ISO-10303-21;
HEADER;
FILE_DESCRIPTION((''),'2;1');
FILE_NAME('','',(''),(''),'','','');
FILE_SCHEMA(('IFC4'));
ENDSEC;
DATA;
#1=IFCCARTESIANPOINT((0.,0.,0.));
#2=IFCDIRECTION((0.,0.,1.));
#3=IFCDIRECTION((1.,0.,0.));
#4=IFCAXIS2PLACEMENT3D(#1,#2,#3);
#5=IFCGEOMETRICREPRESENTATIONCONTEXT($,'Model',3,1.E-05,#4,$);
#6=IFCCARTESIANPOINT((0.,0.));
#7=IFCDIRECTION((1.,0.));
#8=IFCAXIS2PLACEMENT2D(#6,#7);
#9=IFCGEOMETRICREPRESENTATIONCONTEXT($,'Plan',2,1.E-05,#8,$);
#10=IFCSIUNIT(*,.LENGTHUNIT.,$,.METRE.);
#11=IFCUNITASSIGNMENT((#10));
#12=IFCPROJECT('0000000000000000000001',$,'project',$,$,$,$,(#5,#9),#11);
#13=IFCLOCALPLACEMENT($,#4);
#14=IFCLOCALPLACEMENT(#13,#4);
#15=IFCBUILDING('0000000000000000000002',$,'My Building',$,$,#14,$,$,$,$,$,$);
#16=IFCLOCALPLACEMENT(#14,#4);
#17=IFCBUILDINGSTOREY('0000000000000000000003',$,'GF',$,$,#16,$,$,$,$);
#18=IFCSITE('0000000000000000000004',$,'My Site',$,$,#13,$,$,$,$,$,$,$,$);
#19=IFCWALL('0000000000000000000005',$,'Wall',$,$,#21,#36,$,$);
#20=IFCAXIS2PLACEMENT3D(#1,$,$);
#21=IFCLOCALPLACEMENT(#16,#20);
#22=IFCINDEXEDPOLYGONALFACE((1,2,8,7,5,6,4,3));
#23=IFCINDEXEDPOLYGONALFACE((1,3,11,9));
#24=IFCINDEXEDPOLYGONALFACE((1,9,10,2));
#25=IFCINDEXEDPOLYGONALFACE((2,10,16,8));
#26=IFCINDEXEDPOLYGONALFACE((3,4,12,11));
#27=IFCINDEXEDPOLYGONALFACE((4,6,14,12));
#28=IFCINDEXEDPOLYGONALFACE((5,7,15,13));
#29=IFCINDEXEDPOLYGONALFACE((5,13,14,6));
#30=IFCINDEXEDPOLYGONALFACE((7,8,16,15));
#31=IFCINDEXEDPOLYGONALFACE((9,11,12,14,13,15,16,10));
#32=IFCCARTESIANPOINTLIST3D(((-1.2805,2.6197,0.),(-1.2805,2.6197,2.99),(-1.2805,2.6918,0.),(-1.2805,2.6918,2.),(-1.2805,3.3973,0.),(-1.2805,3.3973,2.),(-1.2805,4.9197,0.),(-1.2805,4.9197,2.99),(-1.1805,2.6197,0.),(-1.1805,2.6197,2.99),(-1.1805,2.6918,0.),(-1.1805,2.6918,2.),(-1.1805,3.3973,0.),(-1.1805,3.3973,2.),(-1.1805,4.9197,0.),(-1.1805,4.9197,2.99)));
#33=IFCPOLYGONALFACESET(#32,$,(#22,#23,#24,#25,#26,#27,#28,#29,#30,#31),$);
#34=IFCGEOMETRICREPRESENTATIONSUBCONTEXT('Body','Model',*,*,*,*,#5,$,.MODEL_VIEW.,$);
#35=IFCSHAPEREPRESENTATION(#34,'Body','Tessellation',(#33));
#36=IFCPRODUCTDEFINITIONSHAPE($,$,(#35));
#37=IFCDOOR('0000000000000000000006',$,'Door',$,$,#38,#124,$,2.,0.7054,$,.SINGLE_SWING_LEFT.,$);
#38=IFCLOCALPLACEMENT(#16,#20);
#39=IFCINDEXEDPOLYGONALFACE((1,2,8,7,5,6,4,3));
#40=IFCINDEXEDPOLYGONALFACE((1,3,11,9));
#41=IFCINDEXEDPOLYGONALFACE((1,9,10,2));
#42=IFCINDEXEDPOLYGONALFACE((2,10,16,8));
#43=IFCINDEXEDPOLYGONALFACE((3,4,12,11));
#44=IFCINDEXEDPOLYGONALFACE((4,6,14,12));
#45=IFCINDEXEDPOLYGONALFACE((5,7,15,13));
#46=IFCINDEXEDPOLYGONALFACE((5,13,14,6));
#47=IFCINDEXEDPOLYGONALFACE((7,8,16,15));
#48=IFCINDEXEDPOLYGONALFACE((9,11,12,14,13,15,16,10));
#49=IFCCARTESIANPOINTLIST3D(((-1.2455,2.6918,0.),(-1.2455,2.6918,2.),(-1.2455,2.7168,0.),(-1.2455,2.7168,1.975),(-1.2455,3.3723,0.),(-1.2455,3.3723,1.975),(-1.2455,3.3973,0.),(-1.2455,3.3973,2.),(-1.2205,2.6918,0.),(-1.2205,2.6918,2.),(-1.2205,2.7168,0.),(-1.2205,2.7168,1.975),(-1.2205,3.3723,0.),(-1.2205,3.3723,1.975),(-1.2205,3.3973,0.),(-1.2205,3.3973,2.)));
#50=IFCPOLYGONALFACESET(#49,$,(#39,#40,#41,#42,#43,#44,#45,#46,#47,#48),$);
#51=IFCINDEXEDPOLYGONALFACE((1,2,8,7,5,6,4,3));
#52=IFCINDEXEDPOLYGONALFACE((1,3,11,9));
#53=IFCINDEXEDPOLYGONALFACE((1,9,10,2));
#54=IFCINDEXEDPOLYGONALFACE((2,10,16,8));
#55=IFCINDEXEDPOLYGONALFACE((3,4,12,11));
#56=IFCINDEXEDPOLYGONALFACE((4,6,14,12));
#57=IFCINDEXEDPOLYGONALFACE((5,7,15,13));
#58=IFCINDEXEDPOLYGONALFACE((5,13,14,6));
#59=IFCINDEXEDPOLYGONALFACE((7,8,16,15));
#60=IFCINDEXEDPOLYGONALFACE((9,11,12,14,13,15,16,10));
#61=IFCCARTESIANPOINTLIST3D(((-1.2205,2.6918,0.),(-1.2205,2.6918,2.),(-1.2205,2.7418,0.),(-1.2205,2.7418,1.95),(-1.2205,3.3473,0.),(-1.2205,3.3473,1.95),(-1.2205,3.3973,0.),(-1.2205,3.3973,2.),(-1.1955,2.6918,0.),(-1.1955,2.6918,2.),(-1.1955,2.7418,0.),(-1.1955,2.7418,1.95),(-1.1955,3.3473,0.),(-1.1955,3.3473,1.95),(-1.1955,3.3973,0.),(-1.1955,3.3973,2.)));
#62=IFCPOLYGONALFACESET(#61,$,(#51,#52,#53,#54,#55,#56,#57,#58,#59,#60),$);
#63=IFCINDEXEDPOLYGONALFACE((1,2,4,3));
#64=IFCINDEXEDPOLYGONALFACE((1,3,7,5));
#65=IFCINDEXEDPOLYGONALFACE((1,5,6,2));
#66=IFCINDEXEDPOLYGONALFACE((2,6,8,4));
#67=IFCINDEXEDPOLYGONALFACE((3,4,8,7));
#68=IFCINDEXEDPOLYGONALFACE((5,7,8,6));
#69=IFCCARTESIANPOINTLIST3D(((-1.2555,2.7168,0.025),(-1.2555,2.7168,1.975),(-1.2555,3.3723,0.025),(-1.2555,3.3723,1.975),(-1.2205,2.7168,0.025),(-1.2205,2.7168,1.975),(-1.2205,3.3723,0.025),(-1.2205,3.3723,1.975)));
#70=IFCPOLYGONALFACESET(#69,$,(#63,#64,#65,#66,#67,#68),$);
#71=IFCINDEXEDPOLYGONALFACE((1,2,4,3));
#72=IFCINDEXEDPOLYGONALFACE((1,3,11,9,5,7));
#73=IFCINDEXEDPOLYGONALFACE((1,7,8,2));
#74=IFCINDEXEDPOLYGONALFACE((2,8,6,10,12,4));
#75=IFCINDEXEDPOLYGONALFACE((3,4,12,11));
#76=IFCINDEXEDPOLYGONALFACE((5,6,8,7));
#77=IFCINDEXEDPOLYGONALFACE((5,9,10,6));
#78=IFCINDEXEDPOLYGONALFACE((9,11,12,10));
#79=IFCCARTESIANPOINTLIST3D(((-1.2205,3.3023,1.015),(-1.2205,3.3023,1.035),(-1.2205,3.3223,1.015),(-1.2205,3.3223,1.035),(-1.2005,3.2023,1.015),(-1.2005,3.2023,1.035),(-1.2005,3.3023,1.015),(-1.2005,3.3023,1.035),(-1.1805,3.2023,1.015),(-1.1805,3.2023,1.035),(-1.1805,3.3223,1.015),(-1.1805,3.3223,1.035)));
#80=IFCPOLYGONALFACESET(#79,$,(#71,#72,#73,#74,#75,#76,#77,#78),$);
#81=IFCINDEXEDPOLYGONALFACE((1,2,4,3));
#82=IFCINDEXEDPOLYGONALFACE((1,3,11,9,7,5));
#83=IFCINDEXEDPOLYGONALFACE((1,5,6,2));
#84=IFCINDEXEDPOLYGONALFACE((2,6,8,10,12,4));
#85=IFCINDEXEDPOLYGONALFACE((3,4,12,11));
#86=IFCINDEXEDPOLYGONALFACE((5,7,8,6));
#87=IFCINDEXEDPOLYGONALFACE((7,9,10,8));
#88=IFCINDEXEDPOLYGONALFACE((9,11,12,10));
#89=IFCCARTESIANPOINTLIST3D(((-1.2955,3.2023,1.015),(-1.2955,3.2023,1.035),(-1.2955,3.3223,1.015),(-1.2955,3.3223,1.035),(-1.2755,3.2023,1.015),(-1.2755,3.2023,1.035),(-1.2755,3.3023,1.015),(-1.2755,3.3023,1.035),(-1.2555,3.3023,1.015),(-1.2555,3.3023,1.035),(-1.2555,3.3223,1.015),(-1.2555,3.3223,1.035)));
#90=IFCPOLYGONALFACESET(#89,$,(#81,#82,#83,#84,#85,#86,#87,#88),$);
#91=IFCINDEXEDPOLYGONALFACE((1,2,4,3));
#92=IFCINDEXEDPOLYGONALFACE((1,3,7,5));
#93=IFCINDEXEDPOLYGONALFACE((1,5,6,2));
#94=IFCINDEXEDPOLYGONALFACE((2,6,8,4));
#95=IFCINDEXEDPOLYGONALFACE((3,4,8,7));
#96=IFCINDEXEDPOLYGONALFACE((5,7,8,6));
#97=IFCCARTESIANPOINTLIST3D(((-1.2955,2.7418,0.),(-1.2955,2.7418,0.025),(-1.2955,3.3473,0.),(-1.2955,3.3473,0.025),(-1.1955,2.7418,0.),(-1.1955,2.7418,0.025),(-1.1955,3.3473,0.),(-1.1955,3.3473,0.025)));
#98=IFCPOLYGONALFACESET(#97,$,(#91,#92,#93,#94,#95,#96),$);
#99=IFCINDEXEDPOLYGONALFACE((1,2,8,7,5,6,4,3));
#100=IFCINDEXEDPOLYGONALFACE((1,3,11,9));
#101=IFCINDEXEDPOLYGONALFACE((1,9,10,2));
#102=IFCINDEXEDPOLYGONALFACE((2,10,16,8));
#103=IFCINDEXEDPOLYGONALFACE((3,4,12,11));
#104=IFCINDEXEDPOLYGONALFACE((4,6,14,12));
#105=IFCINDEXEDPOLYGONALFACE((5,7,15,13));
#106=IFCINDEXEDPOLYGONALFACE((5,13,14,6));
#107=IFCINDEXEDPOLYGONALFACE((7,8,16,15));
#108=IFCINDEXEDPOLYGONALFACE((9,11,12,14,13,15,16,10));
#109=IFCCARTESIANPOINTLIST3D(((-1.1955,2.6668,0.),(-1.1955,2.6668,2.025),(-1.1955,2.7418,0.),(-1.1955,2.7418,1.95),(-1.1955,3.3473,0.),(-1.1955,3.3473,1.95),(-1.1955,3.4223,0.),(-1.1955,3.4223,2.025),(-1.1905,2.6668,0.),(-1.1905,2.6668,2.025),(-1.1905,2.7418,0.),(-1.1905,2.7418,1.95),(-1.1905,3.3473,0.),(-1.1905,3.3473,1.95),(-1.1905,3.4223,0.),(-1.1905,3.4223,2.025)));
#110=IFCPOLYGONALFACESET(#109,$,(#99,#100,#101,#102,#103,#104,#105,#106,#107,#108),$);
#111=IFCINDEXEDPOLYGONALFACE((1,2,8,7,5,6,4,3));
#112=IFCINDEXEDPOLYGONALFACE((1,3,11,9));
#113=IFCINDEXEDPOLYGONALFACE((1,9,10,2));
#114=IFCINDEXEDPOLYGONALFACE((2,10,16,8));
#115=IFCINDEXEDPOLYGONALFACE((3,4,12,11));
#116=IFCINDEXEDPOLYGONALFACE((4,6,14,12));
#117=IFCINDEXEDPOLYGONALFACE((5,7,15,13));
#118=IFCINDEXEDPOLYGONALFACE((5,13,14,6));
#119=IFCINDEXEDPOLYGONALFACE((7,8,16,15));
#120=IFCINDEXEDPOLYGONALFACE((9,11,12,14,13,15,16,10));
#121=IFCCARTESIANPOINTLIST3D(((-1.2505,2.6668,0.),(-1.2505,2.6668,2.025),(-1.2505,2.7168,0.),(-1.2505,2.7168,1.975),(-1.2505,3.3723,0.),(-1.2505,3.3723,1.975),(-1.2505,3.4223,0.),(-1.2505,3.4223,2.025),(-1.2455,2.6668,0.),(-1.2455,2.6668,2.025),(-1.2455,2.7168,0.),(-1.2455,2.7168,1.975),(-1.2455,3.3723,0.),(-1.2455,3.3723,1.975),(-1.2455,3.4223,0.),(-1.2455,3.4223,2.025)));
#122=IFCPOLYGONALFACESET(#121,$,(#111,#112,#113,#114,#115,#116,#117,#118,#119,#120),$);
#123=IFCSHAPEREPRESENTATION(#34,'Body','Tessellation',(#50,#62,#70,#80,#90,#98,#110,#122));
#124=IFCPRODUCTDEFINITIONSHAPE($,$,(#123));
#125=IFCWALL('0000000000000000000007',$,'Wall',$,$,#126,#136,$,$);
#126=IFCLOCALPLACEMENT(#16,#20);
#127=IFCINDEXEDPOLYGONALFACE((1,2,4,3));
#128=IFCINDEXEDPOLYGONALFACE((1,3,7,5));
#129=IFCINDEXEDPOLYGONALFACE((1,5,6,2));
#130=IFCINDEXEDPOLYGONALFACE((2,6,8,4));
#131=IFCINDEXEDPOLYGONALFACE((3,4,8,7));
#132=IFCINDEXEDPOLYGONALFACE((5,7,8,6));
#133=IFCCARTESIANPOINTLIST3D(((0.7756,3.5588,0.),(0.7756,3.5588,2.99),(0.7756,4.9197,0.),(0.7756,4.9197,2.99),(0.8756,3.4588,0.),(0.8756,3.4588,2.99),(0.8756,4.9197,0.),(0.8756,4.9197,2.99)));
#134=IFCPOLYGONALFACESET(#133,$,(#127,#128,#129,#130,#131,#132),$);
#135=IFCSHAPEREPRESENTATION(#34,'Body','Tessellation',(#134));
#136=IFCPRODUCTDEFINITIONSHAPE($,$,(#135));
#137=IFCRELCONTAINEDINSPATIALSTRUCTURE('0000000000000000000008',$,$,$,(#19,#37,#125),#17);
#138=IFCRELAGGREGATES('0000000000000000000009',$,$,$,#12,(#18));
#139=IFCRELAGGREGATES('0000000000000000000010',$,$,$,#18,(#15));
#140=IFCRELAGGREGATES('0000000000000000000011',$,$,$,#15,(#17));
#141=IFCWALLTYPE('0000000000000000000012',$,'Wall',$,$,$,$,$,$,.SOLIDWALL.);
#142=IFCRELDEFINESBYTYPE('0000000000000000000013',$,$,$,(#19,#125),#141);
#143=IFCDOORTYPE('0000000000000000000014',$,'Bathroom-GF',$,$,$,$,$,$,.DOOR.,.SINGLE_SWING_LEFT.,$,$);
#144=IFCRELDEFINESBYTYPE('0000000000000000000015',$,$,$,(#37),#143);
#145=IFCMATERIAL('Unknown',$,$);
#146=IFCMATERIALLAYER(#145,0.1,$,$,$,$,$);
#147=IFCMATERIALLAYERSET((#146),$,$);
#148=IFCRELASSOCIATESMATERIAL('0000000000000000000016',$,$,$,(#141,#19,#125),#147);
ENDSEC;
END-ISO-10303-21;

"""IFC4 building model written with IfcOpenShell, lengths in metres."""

from ifc_helpers import new_model, entity, si_unit, frame, origin_with_axes, origin_2d_with_axis, place, context, subcontext, project, spatial, line, indexed_curve, outline, extrude, shape, source, transform, mapped, material, layer, layer_set, layer_usage, type_object, type_shapes, element, fill, save


model = new_model("IFC4")

# Units and contexts
model_context = context("Model", 3, precision=1e-05, world=origin_with_axes())
plan_context = context("Plan", 2, precision=1e-05, world=origin_2d_with_axis())
body_context_1 = subcontext(model_context, "Body", "Model", "MODEL_VIEW")
body_context_2 = subcontext(plan_context, "Body", "Plan", "PLAN_VIEW")
ifc_project = project(units=[si_unit("LENGTHUNIT", "METRE")], contexts=[model_context, plan_context])

# Site, building, storey
site_placement = place(None, origin_with_axes())
site = spatial("IfcSite", under=ifc_project, at=site_placement, Name="My Site")
building_placement = place(site_placement, origin_with_axes())
building = spatial("IfcBuilding", under=site, at=building_placement, Name="My Building")
storey_placement = place(building_placement, origin_with_axes())
storey = spatial("IfcBuildingStorey", under=building, at=storey_placement, Name="GF")

# Shared definitions
ifc_material = material(Name="Unknown")

# Shared definitions
ifc_layer_1 = layer(ifc_material, 0.1)
ifc_layer_set_1 = layer_set([ifc_layer_1])
wall_type = type_object("IfcWallType", Name="Wall", PredefinedType="SOLIDWALL", material=ifc_layer_set_1)

# Wall, opening, door
ifc_layer_usage_1 = layer_usage(ifc_layer_set_1, "AXIS2", "POSITIVE", 0.0)
wall_1_placement = place(storey_placement, frame((-1.1805, 2.6197, 0.0), z_axis=(0.0, 0.0, 1.0), x_axis=(0.0, 1.0, 0.0)))
wall_1 = element("IfcWall", 1, at=wall_1_placement, inside=storey, type_object=wall_type, material=ifc_layer_usage_1, Name="Wall", context=body_context_1, shape_type="SweptSolid", body=[
    extrude(outline(indexed_curve([(0.0, 0.0), (0.0, 0.1), (2.3, 0.1), (2.3, 0.0)], segments=[line(1, 2, 3, 4, 1)])), origin_with_axes(), (0.0, 0.0, 1.0), 2.99),
])
shared_shape_1 = source(origin_with_axes(), body_context_1, "Body", "SweptSolid", [
    extrude(outline(indexed_curve([(0.0, 0.0), (0.7054, 0.0), (0.7054, 2.0), (0.0, 2.0)], segments=[line(1, 2, 3, 4, 1)])), frame((0.0, -0.6, 0.0), z_axis=(0.0, -1.0, 0.0), x_axis=(1.0, 0.0, 0.0)), (0.0, 0.0, -1.0), 1.2),
])
opening_1_placement = place(wall_1_placement, frame((0.0721, 0.015, 0.0), z_axis=(0.0, 0.0, 1.0), x_axis=(1.0, 0.0, 0.0)))
opening_1 = element("IfcOpeningElement", 2, at=opening_1_placement, cuts=wall_1, PredefinedType="OPENING", context=body_context_1, shape_type="MappedRepresentation", body=[
    mapped(shared_shape_1, transform((0.0, 0.0, 0.0), x_axis=(1.0, 0.0, 0.0), y_axis=(0.0, 1.0, 0.0), z_axis=(0.0, 0.0, 1.0), scale=1.0)),
])
door_type_1 = type_object("IfcDoorType", Name="Bathroom-GF", OperationType="SINGLE_SWING_LEFT", PredefinedType="DOOR")
shared_shape_2 = source(origin_with_axes(), body_context_1, "Body", "SweptSolid", [
    extrude(outline(indexed_curve([(0.0, 0.0), (0.0, 2.0), (0.7054, 2.0), (0.7054, 0.0), (0.6804, 0.0), (0.6804, 1.975), (0.025, 1.975), (0.025, 0.0)], segments=[line(1, 2, 3, 4, 5, 6, 7, 8, 1)])), frame((0.0, 0.025, 0.0), z_axis=(0.0, -1.0, 0.0), x_axis=(1.0, 0.0, 0.0)), (0.0, 0.0, -1.0), 0.025),
    extrude(outline(indexed_curve([(0.0, 0.0), (0.0, 2.0), (0.7054, 2.0), (0.7054, 0.0), (0.6554, 0.0), (0.6554, 1.95), (0.05, 1.95), (0.05, 0.0)], segments=[line(1, 2, 3, 4, 5, 6, 7, 8, 1)])), frame((0.0, 0.0, 0.0), z_axis=(0.0, -1.0, 0.0), x_axis=(1.0, 0.0, 0.0)), (0.0, 0.0, -1.0), 0.025),
    extrude(outline(indexed_curve([(0.0, 0.0), (0.6554, 0.0), (0.6554, 0.035), (0.0, 0.035)], segments=[line(1, 2, 3, 4, 1)])), frame((0.025, 0.025, 0.025), z_axis=(0.0, 0.0, 1.0), x_axis=(1.0, 0.0, 0.0)), (0.0, 0.0, 1.0), 1.95),
    extrude(outline(indexed_curve([(0.0, 0.0), (0.0, -0.04), (-0.12, -0.04), (-0.12, -0.02), (-0.02, -0.02), (-0.02, 0.0)], segments=[line(1, 2, 3, 4, 5, 6, 1)])), frame((0.6304, 0.025, 1.015), z_axis=(0.0, 0.0, 1.0), x_axis=(1.0, 0.0, 0.0)), (0.0, 0.0, 1.0), 0.02),
    extrude(outline(indexed_curve([(0.0, 0.0), (0.0, 0.04), (-0.12, 0.04), (-0.12, 0.02), (-0.02, 0.02), (-0.02, 0.0)], segments=[line(1, 2, 3, 4, 5, 6, 1)])), frame((0.6304, 0.06, 1.015), z_axis=(0.0, 0.0, 1.0), x_axis=(1.0, 0.0, 0.0)), (0.0, 0.0, 1.0), 0.02),
    extrude(outline(indexed_curve([(0.0, 0.0), (0.6054, 0.0), (0.6054, 0.1), (0.0, 0.1)], segments=[line(1, 2, 3, 4, 1)])), frame((0.05, 0.0, 0.0), z_axis=(0.0, 0.0, 1.0), x_axis=(1.0, 0.0, 0.0)), (0.0, 0.0, 1.0), 0.025),
    extrude(outline(indexed_curve([(0.0, 0.0), (0.0, 2.025), (0.7554, 2.025), (0.7554, 0.0), (0.6804, 0.0), (0.6804, 1.95), (0.075, 1.95), (0.075, 0.0)], segments=[line(1, 2, 3, 4, 5, 6, 7, 8, 1)])), frame((-0.025, -0.005, 0.0), z_axis=(0.0, -1.0, 0.0), x_axis=(1.0, 0.0, 0.0)), (0.0, 0.0, -1.0), 0.005),
    extrude(outline(indexed_curve([(0.0, 0.0), (0.0, 2.025), (0.7554, 2.025), (0.7554, 0.0), (0.7054, 0.0), (0.7054, 1.975), (0.05, 1.975), (0.05, 0.0)], segments=[line(1, 2, 3, 4, 5, 6, 7, 8, 1)])), frame((-0.025, 0.05, 0.0), z_axis=(0.0, -1.0, 0.0), x_axis=(1.0, 0.0, 0.0)), (0.0, 0.0, -1.0), 0.005),
])
shared_shape_3 = source(origin_with_axes(), body_context_2, "Body", "Curve2D", [
    entity("IfcIndexedPolyCurve", entity("IfcCartesianPointList2D", [[0.0, 0.0], [0.0, 0.05], [0.025, 0.05], [0.025, 0.025], [0.05, 0.025], [0.05, 0.0]]), [entity("IfcLineIndex", [1, 2, 3, 4, 5, 6, 1])]),
    entity("IfcIndexedPolyCurve", entity("IfcCartesianPointList2D", [[0.7054, 0.0], [0.7054, 0.05], [0.6804, 0.05], [0.6804, 0.025], [0.6554, 0.025], [0.6554, 0.0]]), [entity("IfcLineIndex", [1, 2, 3, 4, 5, 6, 1])]),
    entity("IfcTrimmedCurve", entity("IfcEllipse", entity("IfcAxis2Placement2D", entity("IfcCartesianPoint", [0.06, 0.05]), entity("IfcDirection", [1.0, 0.0])), 0.6204, 0.6554), [entity("IfcCartesianPoint", [0.6804, 0.05])], [entity("IfcCartesianPoint", [0.06, 0.7054])], True, "CARTESIAN"),
    entity("IfcIndexedPolyCurve", entity("IfcCartesianPointList2D", [[0.025, 0.05], [0.06, 0.05], [0.06, 0.7054], [0.025, 0.7054]]), [entity("IfcLineIndex", [1, 2, 3, 4, 1])]),
])
type_shapes(door_type_1, [shared_shape_2, shared_shape_3])
door_1_placement = place(opening_1_placement, frame((0.0, 0.0, 0.0), z_axis=(0.0, 0.0, 1.0), x_axis=(1.0, 0.0, 0.0)))
door_1 = element("IfcDoor", 3, at=door_1_placement, inside=storey, type_object=door_type_1, Name="Door", OperationType="SINGLE_SWING_LEFT", OverallHeight=2.0, OverallWidth=0.7054, shapes=[
    shape(body_context_1, "Body", "MappedRepresentation", [mapped(shared_shape_2, transform((0.0, 0.0, 0.0), x_axis=(1.0, 0.0, 0.0), y_axis=(0.0, 1.0, 0.0), z_axis=(0.0, 0.0, 1.0), scale=1.0))]),
    shape(body_context_2, "Body", "MappedRepresentation", [mapped(shared_shape_3, transform((0.0, 0.0, 0.0), x_axis=(1.0, 0.0, 0.0), y_axis=(0.0, 1.0, 0.0), z_axis=(0.0, 0.0, 1.0), scale=1.0))]),
])
fill(opening_1, door_1)

# Wall
ifc_layer_usage_2 = layer_usage(ifc_layer_set_1, "AXIS2", "POSITIVE", 0.0)
wall_2_placement = place(storey_placement, frame((0.7756, 5.0197, 0.0), z_axis=(0.0, 0.0, 1.0), x_axis=(0.0, -1.0, 0.0)))
element("IfcWall", 4, at=wall_2_placement, inside=storey, type_object=wall_type, material=ifc_layer_usage_2, Name="Wall", context=body_context_1, shape_type="SweptSolid", body=[
    extrude(outline(indexed_curve([(0.1, 0.0), (0.1, 0.1), (1.561, 0.1), (1.461, 0.0)], segments=[line(1, 2, 3, 4, 1)])), origin_with_axes(), (0.0, 0.0, 1.0), 2.99),
])

save(model, "model.ifc")
